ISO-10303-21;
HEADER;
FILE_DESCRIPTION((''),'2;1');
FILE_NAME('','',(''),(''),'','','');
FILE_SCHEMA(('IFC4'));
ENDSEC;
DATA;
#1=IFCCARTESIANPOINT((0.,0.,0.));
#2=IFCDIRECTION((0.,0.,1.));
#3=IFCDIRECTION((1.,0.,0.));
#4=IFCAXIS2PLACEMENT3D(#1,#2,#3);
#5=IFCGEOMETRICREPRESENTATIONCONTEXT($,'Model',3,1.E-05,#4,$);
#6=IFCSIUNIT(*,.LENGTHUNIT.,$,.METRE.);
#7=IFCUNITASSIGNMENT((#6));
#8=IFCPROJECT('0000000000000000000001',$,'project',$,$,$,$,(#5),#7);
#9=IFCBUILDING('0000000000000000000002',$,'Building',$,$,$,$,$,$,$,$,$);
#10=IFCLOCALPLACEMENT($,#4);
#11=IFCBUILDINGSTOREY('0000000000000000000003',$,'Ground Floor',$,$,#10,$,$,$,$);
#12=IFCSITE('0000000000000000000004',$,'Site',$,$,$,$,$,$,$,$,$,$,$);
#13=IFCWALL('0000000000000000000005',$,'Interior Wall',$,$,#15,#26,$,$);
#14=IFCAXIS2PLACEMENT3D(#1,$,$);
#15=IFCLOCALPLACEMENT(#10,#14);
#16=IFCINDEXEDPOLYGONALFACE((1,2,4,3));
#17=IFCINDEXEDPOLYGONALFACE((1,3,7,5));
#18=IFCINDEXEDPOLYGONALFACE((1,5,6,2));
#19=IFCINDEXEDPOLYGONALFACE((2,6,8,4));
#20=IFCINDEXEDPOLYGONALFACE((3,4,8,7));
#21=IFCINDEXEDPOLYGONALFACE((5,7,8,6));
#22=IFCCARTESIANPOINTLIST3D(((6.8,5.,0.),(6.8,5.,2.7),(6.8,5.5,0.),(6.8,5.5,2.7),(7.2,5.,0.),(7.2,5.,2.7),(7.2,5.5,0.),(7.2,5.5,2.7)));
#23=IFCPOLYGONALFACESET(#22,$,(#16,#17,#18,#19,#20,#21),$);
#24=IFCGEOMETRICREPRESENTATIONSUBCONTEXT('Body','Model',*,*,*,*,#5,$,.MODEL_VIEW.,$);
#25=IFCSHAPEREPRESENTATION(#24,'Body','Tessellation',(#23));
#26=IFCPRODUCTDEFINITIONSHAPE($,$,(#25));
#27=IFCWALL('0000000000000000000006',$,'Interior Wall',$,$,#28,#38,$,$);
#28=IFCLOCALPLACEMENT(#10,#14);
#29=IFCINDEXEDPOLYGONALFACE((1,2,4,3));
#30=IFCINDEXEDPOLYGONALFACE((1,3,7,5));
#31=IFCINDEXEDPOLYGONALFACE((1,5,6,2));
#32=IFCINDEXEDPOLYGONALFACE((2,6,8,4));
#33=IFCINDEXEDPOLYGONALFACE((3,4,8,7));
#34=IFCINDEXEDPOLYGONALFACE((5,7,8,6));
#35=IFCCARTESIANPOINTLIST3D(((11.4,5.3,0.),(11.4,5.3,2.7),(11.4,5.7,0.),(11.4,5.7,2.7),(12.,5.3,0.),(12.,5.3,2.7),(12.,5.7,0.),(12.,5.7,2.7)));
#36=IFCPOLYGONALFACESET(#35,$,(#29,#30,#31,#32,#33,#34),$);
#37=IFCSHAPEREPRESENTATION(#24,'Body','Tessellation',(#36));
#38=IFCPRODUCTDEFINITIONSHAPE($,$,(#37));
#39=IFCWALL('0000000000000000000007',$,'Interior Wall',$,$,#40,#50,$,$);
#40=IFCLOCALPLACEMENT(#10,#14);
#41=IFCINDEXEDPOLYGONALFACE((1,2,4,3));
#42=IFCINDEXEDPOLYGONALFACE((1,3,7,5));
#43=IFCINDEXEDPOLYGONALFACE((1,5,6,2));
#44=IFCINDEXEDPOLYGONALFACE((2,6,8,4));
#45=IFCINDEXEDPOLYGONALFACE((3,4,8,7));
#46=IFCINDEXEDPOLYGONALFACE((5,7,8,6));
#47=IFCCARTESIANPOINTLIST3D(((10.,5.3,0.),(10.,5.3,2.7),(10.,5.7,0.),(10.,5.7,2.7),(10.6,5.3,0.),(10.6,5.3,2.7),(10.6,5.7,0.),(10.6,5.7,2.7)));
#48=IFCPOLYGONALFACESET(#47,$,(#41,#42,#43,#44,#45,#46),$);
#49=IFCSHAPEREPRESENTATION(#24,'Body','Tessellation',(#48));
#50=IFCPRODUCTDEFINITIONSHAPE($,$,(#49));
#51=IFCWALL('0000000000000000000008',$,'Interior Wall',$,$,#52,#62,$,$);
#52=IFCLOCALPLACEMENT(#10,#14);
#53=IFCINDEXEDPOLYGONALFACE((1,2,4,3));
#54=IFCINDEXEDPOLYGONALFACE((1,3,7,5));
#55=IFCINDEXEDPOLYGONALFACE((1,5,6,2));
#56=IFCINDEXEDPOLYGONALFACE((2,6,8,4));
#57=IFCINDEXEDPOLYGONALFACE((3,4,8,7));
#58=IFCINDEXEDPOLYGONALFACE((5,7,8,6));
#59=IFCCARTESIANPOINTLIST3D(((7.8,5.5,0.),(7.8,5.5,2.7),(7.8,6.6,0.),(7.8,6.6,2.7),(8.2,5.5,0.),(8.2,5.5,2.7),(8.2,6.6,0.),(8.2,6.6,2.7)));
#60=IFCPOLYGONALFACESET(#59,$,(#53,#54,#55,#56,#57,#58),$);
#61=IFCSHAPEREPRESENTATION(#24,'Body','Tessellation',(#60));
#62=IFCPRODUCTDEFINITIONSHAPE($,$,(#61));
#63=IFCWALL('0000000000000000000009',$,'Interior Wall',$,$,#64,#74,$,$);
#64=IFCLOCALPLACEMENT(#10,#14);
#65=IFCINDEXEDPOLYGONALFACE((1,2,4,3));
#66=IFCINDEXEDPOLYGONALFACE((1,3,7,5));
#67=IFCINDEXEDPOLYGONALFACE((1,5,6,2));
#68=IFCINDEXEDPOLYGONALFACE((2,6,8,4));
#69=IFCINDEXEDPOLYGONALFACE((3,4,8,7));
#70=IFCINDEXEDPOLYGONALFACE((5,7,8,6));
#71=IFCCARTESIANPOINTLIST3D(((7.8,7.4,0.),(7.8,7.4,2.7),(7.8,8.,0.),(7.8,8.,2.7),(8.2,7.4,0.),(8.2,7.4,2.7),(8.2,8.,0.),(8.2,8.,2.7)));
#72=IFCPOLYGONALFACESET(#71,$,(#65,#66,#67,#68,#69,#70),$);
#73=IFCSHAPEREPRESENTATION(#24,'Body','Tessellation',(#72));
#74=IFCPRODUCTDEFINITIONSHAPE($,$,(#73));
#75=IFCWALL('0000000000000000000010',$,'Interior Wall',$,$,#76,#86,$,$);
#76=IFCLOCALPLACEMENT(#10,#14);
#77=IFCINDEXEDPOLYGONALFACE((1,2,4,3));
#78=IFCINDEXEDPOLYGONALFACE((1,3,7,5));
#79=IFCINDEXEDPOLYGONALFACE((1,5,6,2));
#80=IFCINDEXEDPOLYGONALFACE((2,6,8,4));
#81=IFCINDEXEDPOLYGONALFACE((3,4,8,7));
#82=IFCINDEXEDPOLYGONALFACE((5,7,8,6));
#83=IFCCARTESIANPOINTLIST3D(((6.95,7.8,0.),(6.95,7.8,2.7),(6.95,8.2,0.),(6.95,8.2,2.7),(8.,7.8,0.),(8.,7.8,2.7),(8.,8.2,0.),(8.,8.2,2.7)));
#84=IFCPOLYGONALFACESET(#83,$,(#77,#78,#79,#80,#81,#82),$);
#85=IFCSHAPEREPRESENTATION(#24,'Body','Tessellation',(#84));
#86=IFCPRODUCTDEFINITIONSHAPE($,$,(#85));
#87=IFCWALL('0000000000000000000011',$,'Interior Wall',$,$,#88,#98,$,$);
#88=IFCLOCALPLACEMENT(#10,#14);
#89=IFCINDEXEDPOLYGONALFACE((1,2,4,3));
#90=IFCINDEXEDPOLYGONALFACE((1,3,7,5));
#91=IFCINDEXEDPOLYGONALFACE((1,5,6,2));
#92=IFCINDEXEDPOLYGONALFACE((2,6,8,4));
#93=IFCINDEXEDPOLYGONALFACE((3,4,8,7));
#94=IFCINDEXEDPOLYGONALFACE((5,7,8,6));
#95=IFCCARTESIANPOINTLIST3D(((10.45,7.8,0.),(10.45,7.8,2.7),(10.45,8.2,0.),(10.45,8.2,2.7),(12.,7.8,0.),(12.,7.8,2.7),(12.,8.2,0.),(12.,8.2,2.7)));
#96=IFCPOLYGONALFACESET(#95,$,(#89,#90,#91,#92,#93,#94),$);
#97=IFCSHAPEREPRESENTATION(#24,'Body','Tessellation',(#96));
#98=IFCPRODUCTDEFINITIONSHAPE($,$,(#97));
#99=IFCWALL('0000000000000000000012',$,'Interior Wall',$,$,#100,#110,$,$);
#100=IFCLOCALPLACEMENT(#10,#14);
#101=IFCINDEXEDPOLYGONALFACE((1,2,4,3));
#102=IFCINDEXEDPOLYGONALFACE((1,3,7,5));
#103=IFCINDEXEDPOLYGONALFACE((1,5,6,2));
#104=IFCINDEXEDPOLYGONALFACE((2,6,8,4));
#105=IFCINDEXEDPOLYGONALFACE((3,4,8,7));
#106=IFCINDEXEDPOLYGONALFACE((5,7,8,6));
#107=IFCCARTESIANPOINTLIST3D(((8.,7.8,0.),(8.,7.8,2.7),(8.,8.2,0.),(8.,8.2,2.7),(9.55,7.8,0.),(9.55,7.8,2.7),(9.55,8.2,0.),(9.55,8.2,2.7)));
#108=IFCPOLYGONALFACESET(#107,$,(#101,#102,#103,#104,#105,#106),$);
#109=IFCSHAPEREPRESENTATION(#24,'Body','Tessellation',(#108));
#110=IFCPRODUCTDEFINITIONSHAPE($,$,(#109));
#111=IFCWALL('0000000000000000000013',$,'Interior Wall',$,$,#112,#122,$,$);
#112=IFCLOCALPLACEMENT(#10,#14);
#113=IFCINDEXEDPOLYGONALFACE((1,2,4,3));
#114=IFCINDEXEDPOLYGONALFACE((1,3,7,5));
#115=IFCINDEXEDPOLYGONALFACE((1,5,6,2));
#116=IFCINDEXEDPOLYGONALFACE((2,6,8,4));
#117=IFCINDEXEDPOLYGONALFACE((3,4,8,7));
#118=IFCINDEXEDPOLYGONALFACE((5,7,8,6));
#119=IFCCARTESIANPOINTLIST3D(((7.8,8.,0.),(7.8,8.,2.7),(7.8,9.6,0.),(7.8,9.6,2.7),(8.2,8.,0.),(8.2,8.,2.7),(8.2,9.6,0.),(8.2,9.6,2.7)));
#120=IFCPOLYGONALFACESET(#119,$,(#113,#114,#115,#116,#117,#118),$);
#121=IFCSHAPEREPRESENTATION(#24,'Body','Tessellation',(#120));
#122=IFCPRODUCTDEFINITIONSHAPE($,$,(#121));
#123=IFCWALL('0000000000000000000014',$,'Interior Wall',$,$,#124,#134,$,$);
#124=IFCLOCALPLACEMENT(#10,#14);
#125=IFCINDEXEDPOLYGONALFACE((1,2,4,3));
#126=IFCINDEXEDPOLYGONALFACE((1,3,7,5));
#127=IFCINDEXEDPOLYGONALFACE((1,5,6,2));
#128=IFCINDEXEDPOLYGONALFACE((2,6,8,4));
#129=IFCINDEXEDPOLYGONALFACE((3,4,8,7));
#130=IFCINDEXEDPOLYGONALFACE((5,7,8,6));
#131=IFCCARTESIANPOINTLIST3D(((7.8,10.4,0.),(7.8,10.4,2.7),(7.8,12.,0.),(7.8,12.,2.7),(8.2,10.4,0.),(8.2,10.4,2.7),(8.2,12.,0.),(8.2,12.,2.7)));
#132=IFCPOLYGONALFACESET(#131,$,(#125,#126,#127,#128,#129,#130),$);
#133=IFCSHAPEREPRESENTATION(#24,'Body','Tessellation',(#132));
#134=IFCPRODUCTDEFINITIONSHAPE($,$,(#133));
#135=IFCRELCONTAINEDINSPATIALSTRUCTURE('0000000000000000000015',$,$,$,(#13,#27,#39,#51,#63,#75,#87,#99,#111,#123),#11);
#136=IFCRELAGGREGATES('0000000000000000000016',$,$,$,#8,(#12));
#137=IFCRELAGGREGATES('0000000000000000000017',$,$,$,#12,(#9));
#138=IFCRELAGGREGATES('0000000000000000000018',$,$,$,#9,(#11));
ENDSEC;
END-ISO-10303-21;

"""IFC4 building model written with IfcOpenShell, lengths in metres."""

from ifc_helpers import new_model, si_unit, frame, origin_with_axes, place, context, subcontext, project, spatial, indexed_curve, outline, extrude, element, save


model = new_model("IFC4")

# Units and contexts
model_context = context("Model", 3, precision=1e-05, world=origin_with_axes())
body_context = subcontext(model_context, "Body", "Model", "MODEL_VIEW")
ifc_project = project(units=[si_unit("LENGTHUNIT", "METRE")], contexts=[model_context])

# Site, building, storey
site = spatial("IfcSite", under=ifc_project, Name="Site")
building = spatial("IfcBuilding", under=site, Name="Building")
storey_placement = place(None, origin_with_axes())
storey = spatial("IfcBuildingStorey", under=building, at=storey_placement, Name="Ground Floor")

# Walls
wall_1_placement = place(storey_placement, frame((7.0, 5.5, 0.0), z_axis=(0.0, 0.0, 1.0), x_axis=(0.0, -1.0, 0.0)))
element("IfcWall", 1, at=wall_1_placement, inside=storey, Name="Interior Wall", context=body_context, shape_type="SweptSolid", body=[
    extrude(outline(indexed_curve([(0.0, 0.0), (0.0, 0.4), (0.5, 0.4), (0.5, 0.0), (0.0, 0.0)], self_intersect=False)), frame((0.0, -0.2, 0.0), z_axis=(0.0, 0.0, 1.0), x_axis=(1.0, 0.0, 0.0)), (0.0, 0.0, 1.0), 2.7),
])
for number, where, z_axis, x_axis, name in (
    (2, (12.0, 5.5, 0.0), (0.0, 0.0, 1.0), (-1.0, 0.0, 0.0), "Interior Wall"),
    (3, (10.6, 5.5, 0.0), (0.0, 0.0, 1.0), (-1.0, 0.0, 0.0), "Interior Wall"),
):
    element("IfcWall", number, at=place(storey_placement, frame(where, z_axis=z_axis, x_axis=x_axis)), inside=storey, Name=name, context=body_context, shape_type="SweptSolid", body=[
        extrude(outline(indexed_curve([(0.0, 0.0), (0.0, 0.4), (0.6, 0.4), (0.6, 0.0), (0.0, 0.0)], self_intersect=False)), frame((0.0, -0.2, 0.0), z_axis=(0.0, 0.0, 1.0), x_axis=(1.0, 0.0, 0.0)), (0.0, 0.0, 1.0), 2.7),
    ])
wall_2_placement = place(storey_placement, frame((8.0, 5.5, 0.0), z_axis=(0.0, 0.0, 1.0), x_axis=(0.0, 1.0, 0.0)))
element("IfcWall", 4, at=wall_2_placement, inside=storey, Name="Interior Wall", context=body_context, shape_type="SweptSolid", body=[
    extrude(outline(indexed_curve([(0.0, 0.0), (0.0, 0.4), (1.1, 0.4), (1.1, 0.0), (0.0, 0.0)], self_intersect=False)), frame((0.0, -0.2, 0.0), z_axis=(0.0, 0.0, 1.0), x_axis=(1.0, 0.0, 0.0)), (0.0, 0.0, 1.0), 2.7),
])
wall_3_placement = place(storey_placement, frame((8.0, 7.4, 0.0), z_axis=(0.0, 0.0, 1.0), x_axis=(0.0, 1.0, 0.0)))
element("IfcWall", 5, at=wall_3_placement, inside=storey, Name="Interior Wall", context=body_context, shape_type="SweptSolid", body=[
    extrude(outline(indexed_curve([(0.0, 0.0), (0.0, 0.4), (0.6, 0.4), (0.6, 0.0), (0.0, 0.0)], self_intersect=False)), frame((0.0, -0.2, 0.0), z_axis=(0.0, 0.0, 1.0), x_axis=(1.0, 0.0, 0.0)), (0.0, 0.0, 1.0), 2.7),
])
wall_4_placement = place(storey_placement, frame((8.0, 8.0, 0.0), z_axis=(0.0, 0.0, 1.0), x_axis=(-1.0, 0.0, 0.0)))
element("IfcWall", 6, at=wall_4_placement, inside=storey, Name="Interior Wall", context=body_context, shape_type="SweptSolid", body=[
    extrude(outline(indexed_curve([(0.0, 0.0), (0.0, 0.4), (1.05, 0.4), (1.05, 0.0), (0.0, 0.0)], self_intersect=False)), frame((0.0, -0.2, 0.0), z_axis=(0.0, 0.0, 1.0), x_axis=(1.0, 0.0, 0.0)), (0.0, 0.0, 1.0), 2.7),
])
for number, where, z_axis, x_axis, name in (
    (7, (12.0, 8.0, 0.0), (0.0, 0.0, 1.0), (-1.0, 0.0, 0.0), "Interior Wall"),
    (8, (9.55, 8.0, 0.0), (0.0, 0.0, 1.0), (-1.0, 0.0, 0.0), "Interior Wall"),
):
    element("IfcWall", number, at=place(storey_placement, frame(where, z_axis=z_axis, x_axis=x_axis)), inside=storey, Name=name, context=body_context, shape_type="SweptSolid", body=[
        extrude(outline(indexed_curve([(0.0, 0.0), (0.0, 0.4), (1.55, 0.4), (1.55, 0.0), (0.0, 0.0)], self_intersect=False)), frame((0.0, -0.2, 0.0), z_axis=(0.0, 0.0, 1.0), x_axis=(1.0, 0.0, 0.0)), (0.0, 0.0, 1.0), 2.7),
    ])
for number, where, z_axis, x_axis, name in (
    (9, (8.0, 8.0, 0.0), (0.0, 0.0, 1.0), (0.0, 1.0, 0.0), "Interior Wall"),
    (10, (8.0, 10.4, 0.0), (0.0, 0.0, 1.0), (0.0, 1.0, 0.0), "Interior Wall"),
):
    element("IfcWall", number, at=place(storey_placement, frame(where, z_axis=z_axis, x_axis=x_axis)), inside=storey, Name=name, context=body_context, shape_type="SweptSolid", body=[
        extrude(outline(indexed_curve([(0.0, 0.0), (0.0, 0.4), (1.6, 0.4), (1.6, 0.0), (0.0, 0.0)], self_intersect=False)), frame((0.0, -0.2, 0.0), z_axis=(0.0, 0.0, 1.0), x_axis=(1.0, 0.0, 0.0)), (0.0, 0.0, 1.0), 2.7),
    ])

save(model, "model.ifc")
